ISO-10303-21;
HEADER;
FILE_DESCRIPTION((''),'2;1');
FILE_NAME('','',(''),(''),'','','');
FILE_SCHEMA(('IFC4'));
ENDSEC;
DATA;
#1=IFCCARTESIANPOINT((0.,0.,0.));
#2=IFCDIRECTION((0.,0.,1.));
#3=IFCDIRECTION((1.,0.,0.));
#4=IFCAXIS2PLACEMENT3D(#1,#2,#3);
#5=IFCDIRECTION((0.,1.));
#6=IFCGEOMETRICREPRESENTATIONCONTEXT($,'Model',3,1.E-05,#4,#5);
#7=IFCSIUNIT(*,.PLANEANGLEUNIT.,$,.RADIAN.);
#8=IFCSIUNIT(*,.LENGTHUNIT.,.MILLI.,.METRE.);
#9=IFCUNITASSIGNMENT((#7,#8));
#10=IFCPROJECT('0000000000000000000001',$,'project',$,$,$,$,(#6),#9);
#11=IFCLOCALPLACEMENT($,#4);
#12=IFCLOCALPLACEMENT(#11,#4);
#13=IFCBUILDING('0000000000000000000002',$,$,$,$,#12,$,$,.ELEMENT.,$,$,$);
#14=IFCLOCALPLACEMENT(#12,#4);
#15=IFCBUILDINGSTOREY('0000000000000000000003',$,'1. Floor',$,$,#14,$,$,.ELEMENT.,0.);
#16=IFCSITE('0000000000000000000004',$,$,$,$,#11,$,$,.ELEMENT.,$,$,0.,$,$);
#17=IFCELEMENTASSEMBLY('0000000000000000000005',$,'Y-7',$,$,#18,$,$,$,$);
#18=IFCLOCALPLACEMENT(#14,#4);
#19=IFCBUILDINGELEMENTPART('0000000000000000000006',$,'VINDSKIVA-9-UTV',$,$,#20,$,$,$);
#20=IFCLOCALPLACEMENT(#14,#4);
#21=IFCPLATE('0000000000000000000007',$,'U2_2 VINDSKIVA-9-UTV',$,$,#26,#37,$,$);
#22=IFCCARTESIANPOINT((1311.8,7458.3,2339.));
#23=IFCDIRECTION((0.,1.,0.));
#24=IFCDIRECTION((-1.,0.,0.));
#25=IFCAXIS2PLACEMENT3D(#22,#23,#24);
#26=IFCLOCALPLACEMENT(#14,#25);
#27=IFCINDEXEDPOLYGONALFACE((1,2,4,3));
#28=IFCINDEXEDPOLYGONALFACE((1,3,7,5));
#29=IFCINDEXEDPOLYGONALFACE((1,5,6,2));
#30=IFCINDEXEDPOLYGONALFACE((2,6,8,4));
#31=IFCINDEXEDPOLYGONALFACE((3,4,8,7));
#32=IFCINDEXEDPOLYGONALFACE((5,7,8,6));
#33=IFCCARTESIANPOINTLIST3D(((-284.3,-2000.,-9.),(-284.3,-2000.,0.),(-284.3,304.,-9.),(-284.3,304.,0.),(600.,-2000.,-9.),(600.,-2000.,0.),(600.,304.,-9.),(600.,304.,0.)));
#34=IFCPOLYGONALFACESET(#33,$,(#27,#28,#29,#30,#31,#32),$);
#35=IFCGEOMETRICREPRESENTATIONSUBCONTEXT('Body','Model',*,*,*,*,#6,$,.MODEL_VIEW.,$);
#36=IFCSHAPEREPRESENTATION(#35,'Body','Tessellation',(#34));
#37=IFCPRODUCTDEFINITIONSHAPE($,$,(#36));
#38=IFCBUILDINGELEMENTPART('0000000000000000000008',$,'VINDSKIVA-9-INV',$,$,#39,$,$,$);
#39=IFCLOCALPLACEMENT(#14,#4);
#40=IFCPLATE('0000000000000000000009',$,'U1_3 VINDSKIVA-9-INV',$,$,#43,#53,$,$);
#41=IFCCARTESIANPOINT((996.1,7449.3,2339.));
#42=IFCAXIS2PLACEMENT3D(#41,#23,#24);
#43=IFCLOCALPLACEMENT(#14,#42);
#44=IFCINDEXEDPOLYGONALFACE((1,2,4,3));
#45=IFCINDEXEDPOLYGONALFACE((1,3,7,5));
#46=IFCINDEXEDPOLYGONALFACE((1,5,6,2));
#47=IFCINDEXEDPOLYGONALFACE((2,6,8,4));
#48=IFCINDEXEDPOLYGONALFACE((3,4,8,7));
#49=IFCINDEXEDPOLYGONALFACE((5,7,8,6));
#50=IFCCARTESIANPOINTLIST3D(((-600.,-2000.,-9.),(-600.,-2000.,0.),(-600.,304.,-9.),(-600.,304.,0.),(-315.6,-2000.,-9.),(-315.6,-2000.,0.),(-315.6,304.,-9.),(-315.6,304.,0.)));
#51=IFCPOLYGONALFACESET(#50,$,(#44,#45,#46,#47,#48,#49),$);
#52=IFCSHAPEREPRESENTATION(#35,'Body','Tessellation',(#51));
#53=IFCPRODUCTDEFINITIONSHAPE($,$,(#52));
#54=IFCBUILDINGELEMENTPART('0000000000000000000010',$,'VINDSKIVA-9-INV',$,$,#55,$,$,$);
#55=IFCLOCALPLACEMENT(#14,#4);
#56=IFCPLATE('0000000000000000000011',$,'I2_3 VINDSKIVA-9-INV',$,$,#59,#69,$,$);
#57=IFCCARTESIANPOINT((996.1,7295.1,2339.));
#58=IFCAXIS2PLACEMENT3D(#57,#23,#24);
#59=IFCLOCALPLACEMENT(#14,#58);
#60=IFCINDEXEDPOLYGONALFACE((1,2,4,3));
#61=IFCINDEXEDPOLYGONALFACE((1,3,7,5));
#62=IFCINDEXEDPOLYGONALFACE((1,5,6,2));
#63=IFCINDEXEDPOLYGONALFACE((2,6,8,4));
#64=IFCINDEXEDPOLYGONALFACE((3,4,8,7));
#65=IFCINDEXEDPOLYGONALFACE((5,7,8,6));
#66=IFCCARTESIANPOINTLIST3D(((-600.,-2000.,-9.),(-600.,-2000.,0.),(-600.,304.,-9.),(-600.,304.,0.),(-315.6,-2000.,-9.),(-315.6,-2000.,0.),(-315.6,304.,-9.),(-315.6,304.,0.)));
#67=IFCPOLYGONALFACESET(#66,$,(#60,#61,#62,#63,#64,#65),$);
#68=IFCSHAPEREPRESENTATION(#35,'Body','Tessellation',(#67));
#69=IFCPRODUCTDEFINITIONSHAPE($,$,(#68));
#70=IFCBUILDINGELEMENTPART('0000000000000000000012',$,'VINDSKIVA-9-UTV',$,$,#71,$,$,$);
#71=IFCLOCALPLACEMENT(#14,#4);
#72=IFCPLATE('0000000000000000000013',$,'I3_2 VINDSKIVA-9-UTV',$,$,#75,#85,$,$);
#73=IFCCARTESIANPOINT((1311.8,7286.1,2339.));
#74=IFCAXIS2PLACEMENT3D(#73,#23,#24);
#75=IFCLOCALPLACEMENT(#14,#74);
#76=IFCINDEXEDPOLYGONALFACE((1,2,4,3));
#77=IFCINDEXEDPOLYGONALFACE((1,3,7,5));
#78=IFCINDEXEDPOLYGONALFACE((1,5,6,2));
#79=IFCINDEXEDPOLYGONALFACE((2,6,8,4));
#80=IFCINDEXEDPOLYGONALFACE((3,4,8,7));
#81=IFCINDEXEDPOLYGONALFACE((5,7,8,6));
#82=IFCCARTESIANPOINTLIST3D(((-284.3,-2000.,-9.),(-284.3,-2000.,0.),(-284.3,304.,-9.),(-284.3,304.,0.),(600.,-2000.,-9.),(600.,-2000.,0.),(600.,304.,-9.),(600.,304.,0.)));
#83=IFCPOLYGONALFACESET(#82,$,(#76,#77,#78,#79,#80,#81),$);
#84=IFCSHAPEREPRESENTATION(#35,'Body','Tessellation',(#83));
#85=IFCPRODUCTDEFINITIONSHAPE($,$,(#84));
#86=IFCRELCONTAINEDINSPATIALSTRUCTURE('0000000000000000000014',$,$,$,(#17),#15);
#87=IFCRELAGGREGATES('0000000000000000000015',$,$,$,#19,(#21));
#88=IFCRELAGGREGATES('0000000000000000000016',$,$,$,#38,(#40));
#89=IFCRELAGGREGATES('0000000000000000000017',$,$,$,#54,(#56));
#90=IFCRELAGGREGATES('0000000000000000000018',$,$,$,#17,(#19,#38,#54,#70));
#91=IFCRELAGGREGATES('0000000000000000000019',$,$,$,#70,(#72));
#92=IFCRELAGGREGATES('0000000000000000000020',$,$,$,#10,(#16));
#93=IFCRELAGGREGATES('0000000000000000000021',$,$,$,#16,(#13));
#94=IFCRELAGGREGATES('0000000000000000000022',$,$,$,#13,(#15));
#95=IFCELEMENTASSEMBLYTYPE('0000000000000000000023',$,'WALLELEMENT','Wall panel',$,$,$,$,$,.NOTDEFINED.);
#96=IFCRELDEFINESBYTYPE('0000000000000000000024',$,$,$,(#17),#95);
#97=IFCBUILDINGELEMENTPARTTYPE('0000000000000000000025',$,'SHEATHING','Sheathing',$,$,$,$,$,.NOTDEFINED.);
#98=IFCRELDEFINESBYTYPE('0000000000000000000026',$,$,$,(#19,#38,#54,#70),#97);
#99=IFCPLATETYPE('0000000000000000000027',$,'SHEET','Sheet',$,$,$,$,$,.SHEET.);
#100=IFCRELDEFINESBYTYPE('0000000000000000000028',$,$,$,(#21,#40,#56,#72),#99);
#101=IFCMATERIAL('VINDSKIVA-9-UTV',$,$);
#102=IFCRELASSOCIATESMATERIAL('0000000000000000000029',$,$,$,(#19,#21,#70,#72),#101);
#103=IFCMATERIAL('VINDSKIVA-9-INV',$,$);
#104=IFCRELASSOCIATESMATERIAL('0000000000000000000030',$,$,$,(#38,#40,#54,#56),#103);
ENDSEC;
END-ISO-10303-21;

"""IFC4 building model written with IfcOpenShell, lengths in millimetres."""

from ifc_helpers import new_model, si_unit, direction, frame, origin_with_axes, origin_2d_with_axis, place, context, subcontext, project, spatial, rectangle, extrude, material, type_object, element, aggregate, save


model = new_model("IFC4")

# Units and contexts
model_context = context("Model", 3, precision=1e-05, world=origin_with_axes(), true_north=direction((0.0, 1.0)))
body_context = subcontext(model_context, "Body", "Model", "MODEL_VIEW")
ifc_project = project(units=[si_unit("PLANEANGLEUNIT", "RADIAN"), si_unit("LENGTHUNIT", "METRE", prefix="MILLI")], contexts=[model_context])

# Site, building, storey
site_placement = place(None, origin_with_axes())
site = spatial("IfcSite", under=ifc_project, at=site_placement, CompositionType="ELEMENT", RefElevation=0.0)
building_placement = place(site_placement, origin_with_axes())
building = spatial("IfcBuilding", under=site, at=building_placement, CompositionType="ELEMENT")
storey_placement = place(building_placement, origin_with_axes())
storey = spatial("IfcBuildingStorey", under=building, at=storey_placement, Name="1. Floor", CompositionType="ELEMENT", Elevation=0.0)

# Element assembly
element_assembly_type = type_object("IfcElementAssemblyType", Name="WALLELEMENT", Description="Wall panel", PredefinedType="NOTDEFINED")
assembly_1_placement = place(storey_placement, origin_with_axes())
assembly_1 = element("IfcElementAssembly", 1, at=assembly_1_placement, inside=storey, type_object=element_assembly_type, Name="Y-7")

# Shared definitions
ifc_material_1 = material(Name="VINDSKIVA-9-UTV")
building_element_part_type_1 = type_object("IfcBuildingElementPartType", Name="SHEATHING", Description="Sheathing", PredefinedType="NOTDEFINED")
plate_type_1 = type_object("IfcPlateType", Name="SHEET", Description="Sheet", PredefinedType="SHEET")

# Building element parts, plates
building_element_part_1_placement = place(storey_placement, origin_with_axes())
building_element_part_1 = element("IfcBuildingElementPart", 2, at=building_element_part_1_placement, type_object=building_element_part_type_1, material=ifc_material_1, Name="VINDSKIVA-9-UTV")
plate_1_placement = place(storey_placement, frame((1311.8, 7458.3, 2339.0), z_axis=(0.0, 1.0, 0.0), x_axis=(-1.0, 0.0, 0.0)))
plate_1 = element("IfcPlate", 3, at=plate_1_placement, type_object=plate_type_1, material=ifc_material_1, Name="U2_2 VINDSKIVA-9-UTV", context=body_context, shape_type="SweptSolid", body=[
    extrude(rectangle(XDim=9.0, YDim=884.3, at=origin_2d_with_axis()), frame((157.8, -2000.0, -4.5), z_axis=(0.0, 1.0, 0.0), x_axis=(0.0, 0.0, 1.0)), (0.0, 0.0, 1.0), 2304.0),
])
aggregate(building_element_part_1, [plate_1])
ifc_material_2 = material(Name="VINDSKIVA-9-INV")
building_element_part_2_placement = place(storey_placement, origin_with_axes())
building_element_part_2 = element("IfcBuildingElementPart", 4, at=building_element_part_2_placement, type_object=building_element_part_type_1, material=ifc_material_2, Name="VINDSKIVA-9-INV")
plate_2_placement = place(storey_placement, frame((996.1, 7449.3, 2339.0), z_axis=(0.0, 1.0, 0.0), x_axis=(-1.0, 0.0, 0.0)))
plate_2 = element("IfcPlate", 5, at=plate_2_placement, type_object=plate_type_1, material=ifc_material_2, Name="U1_3 VINDSKIVA-9-INV", context=body_context, shape_type="SweptSolid", body=[
    extrude(rectangle(XDim=9.0, YDim=284.4, at=origin_2d_with_axis()), frame((-457.8, -2000.0, -4.5), z_axis=(0.0, 1.0, 0.0), x_axis=(0.0, 0.0, 1.0)), (0.0, 0.0, 1.0), 2304.0),
])
aggregate(building_element_part_2, [plate_2])
building_element_part_3_placement = place(storey_placement, origin_with_axes())
building_element_part_3 = element("IfcBuildingElementPart", 6, at=building_element_part_3_placement, type_object=building_element_part_type_1, material=ifc_material_2, Name="VINDSKIVA-9-INV")
plate_3_placement = place(storey_placement, frame((996.1, 7295.1, 2339.0), z_axis=(0.0, 1.0, 0.0), x_axis=(-1.0, 0.0, 0.0)))
plate_3 = element("IfcPlate", 7, at=plate_3_placement, type_object=plate_type_1, material=ifc_material_2, Name="I2_3 VINDSKIVA-9-INV", context=body_context, shape_type="SweptSolid", body=[
    extrude(rectangle(XDim=9.0, YDim=284.4, at=origin_2d_with_axis()), frame((-457.8, -2000.0, -4.5), z_axis=(0.0, 1.0, 0.0), x_axis=(0.0, 0.0, 1.0)), (0.0, 0.0, 1.0), 2304.0),
])
aggregate(building_element_part_3, [plate_3])

# Building element part
building_element_part_4_placement = place(storey_placement, origin_with_axes())
building_element_part_4 = element("IfcBuildingElementPart", 8, at=building_element_part_4_placement, type_object=building_element_part_type_1, material=ifc_material_1, Name="VINDSKIVA-9-UTV")
aggregate(assembly_1, [building_element_part_1, building_element_part_2, building_element_part_3, building_element_part_4])

# Plate
plate_4_placement = place(storey_placement, frame((1311.8, 7286.1, 2339.0), z_axis=(0.0, 1.0, 0.0), x_axis=(-1.0, 0.0, 0.0)))
plate_4 = element("IfcPlate", 9, at=plate_4_placement, type_object=plate_type_1, material=ifc_material_1, Name="I3_2 VINDSKIVA-9-UTV", context=body_context, shape_type="SweptSolid", body=[
    extrude(rectangle(XDim=9.0, YDim=884.3, at=origin_2d_with_axis()), frame((157.8, -2000.0, -4.5), z_axis=(0.0, 1.0, 0.0), x_axis=(0.0, 0.0, 1.0)), (0.0, 0.0, 1.0), 2304.0),
])
aggregate(building_element_part_4, [plate_4])

save(model, "model.ifc")
